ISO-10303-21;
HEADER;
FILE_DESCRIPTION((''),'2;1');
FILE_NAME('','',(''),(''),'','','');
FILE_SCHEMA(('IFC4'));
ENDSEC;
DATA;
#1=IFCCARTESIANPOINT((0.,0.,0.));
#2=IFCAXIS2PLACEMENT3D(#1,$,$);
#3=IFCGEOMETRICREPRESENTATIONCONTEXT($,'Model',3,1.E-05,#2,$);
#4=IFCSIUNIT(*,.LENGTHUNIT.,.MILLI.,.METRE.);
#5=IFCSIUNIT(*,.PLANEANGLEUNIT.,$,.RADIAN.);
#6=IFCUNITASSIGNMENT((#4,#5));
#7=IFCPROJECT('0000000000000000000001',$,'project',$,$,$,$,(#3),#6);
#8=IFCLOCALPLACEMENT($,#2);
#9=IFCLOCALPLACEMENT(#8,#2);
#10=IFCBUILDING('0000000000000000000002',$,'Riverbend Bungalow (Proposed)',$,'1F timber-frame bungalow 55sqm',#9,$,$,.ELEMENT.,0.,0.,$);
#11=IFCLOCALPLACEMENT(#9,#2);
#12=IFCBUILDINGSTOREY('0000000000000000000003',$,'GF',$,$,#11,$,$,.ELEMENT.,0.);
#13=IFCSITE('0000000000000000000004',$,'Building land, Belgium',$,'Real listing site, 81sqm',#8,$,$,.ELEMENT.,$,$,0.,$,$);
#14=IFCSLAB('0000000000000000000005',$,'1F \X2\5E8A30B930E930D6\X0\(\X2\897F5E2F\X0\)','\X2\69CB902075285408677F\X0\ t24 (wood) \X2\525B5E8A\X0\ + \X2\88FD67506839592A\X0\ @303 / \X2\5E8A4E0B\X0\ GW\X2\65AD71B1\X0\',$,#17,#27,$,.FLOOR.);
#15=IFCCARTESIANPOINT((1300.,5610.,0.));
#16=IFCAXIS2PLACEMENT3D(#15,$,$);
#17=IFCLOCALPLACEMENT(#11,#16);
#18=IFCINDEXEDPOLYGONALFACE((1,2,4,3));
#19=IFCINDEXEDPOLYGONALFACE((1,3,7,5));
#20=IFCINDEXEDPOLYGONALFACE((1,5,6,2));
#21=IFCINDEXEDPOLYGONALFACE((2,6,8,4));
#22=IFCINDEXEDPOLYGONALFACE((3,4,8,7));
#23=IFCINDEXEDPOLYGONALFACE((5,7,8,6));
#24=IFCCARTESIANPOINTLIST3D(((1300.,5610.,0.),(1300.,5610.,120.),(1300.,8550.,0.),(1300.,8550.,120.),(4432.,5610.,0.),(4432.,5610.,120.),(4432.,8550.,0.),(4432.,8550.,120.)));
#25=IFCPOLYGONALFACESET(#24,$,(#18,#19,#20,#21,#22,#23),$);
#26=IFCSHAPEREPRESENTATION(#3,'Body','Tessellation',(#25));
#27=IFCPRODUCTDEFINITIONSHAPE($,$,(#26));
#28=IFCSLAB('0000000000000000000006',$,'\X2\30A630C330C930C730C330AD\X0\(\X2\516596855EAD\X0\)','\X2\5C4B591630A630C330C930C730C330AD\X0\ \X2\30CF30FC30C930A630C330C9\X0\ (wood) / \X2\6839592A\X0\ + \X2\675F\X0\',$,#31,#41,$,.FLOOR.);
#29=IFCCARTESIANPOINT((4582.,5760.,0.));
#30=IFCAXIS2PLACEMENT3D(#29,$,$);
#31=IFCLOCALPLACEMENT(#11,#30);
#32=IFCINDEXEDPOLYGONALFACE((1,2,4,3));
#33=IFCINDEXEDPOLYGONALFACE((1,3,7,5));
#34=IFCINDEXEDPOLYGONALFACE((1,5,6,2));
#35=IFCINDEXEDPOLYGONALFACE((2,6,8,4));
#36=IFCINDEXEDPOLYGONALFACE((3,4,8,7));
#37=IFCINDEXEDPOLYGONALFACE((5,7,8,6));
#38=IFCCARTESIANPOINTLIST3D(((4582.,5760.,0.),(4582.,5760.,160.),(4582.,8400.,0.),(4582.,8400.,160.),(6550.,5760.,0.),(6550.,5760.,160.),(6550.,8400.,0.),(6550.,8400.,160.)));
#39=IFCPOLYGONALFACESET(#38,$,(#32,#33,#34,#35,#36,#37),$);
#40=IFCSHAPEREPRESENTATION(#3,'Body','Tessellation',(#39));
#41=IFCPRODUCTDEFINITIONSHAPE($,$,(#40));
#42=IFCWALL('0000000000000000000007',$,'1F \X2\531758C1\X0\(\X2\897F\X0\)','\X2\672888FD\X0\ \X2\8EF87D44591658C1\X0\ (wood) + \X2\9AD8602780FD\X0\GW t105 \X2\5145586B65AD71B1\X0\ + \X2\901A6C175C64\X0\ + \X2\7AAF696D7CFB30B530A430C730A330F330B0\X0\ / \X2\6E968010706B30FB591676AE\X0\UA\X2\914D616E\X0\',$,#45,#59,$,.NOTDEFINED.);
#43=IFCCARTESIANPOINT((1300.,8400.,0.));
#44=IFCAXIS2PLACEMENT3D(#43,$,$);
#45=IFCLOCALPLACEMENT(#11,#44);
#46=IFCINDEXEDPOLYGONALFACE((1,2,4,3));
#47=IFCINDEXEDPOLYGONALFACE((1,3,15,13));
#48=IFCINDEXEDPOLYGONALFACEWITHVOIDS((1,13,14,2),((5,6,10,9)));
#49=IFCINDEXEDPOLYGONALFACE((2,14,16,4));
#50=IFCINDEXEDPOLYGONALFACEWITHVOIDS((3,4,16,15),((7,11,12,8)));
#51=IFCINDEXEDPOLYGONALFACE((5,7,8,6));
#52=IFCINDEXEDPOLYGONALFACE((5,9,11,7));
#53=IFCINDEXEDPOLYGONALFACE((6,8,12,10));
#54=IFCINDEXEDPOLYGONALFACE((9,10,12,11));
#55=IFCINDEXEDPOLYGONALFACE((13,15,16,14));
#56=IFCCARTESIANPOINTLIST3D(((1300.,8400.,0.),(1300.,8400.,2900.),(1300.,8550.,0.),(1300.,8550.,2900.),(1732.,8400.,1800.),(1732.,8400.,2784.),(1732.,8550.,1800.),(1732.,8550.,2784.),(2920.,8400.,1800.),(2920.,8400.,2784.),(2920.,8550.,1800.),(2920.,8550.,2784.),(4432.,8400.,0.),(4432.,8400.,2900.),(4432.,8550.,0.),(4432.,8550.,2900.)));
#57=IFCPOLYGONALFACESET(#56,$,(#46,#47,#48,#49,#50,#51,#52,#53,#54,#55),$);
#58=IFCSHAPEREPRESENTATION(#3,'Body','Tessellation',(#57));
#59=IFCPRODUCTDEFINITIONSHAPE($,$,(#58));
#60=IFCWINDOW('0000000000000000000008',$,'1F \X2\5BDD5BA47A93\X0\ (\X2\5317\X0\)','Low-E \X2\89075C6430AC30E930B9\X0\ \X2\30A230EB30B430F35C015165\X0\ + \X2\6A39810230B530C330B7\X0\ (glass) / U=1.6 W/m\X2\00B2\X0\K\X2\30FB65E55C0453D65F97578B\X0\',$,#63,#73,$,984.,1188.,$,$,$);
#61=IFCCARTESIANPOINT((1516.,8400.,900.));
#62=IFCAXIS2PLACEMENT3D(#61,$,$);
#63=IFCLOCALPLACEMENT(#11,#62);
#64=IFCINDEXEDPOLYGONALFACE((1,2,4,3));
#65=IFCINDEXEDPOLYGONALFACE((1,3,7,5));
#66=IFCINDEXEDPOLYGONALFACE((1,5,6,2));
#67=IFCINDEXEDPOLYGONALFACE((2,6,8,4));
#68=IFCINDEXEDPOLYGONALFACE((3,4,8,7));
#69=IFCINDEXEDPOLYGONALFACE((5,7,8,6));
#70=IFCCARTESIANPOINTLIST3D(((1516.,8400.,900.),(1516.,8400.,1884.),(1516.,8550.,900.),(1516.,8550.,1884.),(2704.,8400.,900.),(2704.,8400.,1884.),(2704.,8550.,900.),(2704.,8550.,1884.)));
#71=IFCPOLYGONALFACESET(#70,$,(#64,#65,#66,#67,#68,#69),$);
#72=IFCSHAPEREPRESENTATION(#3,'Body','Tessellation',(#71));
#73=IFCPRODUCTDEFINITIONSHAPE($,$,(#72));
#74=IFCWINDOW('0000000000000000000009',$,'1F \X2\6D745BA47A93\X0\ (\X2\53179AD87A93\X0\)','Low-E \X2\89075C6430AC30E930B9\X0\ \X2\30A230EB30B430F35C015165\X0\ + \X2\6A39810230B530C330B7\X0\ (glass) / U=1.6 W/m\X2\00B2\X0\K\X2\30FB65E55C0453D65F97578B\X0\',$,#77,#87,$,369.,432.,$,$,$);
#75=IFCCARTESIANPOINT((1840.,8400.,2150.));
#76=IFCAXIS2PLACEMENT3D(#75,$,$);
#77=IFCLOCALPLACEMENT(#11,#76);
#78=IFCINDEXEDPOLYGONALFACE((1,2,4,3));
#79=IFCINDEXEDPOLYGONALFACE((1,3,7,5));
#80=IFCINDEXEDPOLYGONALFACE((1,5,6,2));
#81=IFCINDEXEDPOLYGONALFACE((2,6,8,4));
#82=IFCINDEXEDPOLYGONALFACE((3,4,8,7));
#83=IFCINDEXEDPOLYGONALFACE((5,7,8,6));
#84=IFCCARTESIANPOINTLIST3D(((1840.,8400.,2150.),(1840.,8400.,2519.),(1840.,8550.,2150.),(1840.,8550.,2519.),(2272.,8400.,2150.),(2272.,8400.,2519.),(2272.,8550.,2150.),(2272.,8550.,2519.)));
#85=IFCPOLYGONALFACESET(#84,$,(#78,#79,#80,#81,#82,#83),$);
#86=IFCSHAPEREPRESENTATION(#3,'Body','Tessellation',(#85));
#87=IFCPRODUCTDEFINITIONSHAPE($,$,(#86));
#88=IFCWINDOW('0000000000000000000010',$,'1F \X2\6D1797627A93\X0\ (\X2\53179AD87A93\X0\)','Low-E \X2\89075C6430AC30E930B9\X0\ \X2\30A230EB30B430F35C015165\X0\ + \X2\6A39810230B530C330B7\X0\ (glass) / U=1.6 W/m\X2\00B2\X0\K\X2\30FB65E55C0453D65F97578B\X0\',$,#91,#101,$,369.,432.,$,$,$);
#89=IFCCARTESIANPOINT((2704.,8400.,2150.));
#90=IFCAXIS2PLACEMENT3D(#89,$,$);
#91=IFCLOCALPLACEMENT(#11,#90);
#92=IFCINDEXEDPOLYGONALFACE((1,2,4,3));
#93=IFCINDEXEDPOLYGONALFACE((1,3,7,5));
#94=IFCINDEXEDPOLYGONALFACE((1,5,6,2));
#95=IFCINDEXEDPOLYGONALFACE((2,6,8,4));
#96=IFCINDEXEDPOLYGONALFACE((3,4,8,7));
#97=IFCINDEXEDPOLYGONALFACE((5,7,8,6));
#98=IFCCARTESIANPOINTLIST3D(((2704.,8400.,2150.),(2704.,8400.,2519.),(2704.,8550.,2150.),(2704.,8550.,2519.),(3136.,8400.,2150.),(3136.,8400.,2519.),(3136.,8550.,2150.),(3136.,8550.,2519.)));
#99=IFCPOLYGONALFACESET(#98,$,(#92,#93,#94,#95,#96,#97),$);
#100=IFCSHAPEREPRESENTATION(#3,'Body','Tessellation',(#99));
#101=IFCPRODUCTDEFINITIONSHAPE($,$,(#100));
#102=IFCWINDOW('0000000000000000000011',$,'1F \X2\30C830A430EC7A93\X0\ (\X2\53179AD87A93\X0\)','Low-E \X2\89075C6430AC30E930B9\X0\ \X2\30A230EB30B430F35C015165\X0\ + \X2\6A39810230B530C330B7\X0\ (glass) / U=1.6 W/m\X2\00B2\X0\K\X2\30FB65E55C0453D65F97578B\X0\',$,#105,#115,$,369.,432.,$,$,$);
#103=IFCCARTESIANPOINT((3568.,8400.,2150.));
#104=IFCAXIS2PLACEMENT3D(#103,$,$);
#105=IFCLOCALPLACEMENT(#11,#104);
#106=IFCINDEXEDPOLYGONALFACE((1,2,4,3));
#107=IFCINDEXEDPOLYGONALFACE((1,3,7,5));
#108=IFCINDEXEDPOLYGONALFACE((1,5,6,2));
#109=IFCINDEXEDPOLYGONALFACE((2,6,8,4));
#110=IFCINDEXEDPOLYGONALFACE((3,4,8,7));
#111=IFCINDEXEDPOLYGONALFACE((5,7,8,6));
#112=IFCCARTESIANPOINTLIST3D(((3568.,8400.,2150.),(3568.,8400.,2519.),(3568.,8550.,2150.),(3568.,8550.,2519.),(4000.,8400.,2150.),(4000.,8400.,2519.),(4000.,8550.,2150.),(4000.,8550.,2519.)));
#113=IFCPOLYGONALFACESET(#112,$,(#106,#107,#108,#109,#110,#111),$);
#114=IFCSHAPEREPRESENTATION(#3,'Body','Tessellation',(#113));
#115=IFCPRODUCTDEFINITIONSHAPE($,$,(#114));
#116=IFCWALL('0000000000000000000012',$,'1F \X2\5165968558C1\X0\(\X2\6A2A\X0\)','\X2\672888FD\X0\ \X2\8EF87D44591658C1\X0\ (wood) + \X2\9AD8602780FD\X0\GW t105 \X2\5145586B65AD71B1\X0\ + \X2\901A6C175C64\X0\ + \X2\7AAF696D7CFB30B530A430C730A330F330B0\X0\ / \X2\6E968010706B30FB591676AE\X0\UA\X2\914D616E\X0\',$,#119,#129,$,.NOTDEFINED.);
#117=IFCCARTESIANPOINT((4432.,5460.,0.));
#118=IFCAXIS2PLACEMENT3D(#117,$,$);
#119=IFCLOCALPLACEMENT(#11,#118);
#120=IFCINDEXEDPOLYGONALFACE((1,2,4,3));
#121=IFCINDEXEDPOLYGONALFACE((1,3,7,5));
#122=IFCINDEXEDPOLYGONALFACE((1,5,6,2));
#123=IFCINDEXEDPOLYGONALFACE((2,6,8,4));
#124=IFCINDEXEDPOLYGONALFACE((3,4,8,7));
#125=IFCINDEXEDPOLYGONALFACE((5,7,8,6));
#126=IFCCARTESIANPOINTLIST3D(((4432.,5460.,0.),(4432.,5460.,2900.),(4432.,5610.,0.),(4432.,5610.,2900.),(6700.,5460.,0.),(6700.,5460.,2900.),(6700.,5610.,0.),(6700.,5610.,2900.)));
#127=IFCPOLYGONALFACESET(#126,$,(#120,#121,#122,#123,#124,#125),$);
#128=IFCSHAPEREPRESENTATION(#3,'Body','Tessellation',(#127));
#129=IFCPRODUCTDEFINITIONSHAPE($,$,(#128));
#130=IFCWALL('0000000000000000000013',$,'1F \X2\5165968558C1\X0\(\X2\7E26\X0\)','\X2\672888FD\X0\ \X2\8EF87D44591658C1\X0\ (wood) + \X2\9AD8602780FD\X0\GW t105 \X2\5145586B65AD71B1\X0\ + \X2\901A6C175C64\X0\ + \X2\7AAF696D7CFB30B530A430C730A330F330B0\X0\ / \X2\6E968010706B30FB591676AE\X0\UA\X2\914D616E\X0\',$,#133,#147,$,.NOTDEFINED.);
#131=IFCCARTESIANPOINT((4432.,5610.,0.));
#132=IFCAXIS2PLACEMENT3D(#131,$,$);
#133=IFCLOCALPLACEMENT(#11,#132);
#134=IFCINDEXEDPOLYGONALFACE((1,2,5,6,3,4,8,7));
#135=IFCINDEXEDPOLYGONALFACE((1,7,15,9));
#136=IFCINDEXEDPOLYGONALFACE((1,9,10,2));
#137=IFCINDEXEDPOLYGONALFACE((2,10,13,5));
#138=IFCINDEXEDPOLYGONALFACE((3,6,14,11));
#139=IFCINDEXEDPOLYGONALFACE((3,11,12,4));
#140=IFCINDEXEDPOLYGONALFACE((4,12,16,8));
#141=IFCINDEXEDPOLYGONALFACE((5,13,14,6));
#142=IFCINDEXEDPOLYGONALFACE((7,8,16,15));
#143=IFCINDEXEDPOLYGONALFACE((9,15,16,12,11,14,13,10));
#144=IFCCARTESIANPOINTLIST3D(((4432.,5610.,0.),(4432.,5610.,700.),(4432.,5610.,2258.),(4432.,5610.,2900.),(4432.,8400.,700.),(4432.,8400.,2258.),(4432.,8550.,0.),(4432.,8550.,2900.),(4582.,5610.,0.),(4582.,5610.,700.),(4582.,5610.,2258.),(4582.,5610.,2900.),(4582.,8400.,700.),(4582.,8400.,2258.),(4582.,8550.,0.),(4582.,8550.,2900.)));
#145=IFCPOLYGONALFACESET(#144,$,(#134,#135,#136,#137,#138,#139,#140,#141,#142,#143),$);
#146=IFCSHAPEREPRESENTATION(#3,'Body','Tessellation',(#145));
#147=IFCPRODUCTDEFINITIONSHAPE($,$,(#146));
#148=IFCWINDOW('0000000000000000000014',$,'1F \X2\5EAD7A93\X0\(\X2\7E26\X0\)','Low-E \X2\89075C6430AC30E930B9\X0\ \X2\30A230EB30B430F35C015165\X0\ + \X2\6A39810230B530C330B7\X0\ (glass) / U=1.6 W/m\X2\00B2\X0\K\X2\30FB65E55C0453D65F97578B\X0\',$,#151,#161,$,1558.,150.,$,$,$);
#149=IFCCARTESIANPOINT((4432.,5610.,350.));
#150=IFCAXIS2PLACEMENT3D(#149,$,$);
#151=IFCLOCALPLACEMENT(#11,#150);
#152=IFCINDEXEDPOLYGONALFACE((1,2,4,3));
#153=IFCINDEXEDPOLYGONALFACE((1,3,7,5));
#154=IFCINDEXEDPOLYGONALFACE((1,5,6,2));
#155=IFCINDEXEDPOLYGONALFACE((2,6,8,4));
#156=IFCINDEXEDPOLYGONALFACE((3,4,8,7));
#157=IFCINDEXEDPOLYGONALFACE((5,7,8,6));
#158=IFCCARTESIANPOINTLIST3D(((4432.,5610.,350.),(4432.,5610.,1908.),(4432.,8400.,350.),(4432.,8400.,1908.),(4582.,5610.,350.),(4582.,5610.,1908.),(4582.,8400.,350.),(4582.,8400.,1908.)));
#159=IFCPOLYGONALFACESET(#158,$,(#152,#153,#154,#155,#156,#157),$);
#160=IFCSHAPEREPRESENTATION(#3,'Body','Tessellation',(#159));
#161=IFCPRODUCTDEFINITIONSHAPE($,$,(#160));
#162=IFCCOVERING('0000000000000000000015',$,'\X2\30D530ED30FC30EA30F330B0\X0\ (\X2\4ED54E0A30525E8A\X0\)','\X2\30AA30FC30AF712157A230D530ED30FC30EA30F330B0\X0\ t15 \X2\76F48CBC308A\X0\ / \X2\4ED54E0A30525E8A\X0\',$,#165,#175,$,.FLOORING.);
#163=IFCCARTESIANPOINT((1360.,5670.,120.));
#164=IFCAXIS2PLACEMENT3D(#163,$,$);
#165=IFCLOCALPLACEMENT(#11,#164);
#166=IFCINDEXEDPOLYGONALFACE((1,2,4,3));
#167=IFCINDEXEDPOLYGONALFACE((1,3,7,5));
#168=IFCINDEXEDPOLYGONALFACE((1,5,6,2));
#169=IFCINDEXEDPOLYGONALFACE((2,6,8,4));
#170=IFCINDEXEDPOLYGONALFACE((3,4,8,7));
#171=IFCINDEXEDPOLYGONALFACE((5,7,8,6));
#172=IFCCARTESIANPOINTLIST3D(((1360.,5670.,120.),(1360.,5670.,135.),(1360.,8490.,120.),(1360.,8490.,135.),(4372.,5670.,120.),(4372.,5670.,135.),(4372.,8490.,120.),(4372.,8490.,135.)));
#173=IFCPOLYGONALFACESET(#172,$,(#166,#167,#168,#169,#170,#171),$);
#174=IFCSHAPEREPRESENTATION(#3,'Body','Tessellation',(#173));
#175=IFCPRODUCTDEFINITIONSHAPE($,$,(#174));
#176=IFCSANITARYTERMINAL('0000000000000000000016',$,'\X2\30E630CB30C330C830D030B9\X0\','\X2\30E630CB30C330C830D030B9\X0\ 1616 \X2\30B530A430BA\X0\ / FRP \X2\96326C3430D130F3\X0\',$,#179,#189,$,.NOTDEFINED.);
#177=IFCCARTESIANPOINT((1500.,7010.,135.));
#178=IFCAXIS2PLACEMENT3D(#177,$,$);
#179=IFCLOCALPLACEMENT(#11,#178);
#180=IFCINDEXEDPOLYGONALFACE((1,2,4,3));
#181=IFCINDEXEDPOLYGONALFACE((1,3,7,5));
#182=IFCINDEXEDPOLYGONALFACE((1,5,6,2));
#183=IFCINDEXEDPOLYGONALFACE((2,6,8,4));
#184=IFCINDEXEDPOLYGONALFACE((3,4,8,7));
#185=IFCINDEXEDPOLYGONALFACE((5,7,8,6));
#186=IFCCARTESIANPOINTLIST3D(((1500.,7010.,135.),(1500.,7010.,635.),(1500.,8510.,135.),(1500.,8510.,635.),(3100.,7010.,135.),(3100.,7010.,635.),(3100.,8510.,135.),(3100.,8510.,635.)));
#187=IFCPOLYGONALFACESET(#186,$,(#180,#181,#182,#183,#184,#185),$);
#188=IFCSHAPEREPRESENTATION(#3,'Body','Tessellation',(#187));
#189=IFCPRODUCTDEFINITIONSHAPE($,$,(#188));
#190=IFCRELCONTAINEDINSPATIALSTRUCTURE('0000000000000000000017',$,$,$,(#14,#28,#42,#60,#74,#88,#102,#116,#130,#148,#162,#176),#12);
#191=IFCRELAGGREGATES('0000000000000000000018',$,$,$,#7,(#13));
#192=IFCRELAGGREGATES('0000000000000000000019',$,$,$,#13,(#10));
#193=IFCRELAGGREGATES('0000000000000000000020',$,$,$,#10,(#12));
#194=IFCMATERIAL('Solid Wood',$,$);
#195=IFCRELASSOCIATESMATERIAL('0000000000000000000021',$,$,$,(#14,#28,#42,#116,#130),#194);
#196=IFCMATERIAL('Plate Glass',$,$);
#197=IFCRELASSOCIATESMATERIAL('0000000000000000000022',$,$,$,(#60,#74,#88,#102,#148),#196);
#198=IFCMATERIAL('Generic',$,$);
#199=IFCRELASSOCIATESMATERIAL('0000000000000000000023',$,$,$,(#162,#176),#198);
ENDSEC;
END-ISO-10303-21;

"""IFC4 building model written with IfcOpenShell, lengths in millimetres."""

from ifc_helpers import new_model, si_unit, frame, frame_2d, origin, place, context, project, spatial, rectangle, extrude, material, element, fill, save


model = new_model("IFC4")

# Units and contexts
model_context = context("Model", 3, precision=1e-05, world=origin())
ifc_project = project(units=[si_unit("LENGTHUNIT", "METRE", prefix="MILLI"), si_unit("PLANEANGLEUNIT", "RADIAN")], contexts=[model_context])

# Site, building, storey
site_placement = place(None, origin())
site = spatial("IfcSite", under=ifc_project, at=site_placement, Name="Building land, Belgium", ObjectType="Real listing site, 81sqm", CompositionType="ELEMENT", RefElevation=0.0)
building_placement = place(site_placement, origin())
building = spatial("IfcBuilding", under=site, at=building_placement, Name="Riverbend Bungalow (Proposed)", ObjectType="1F timber-frame bungalow 55sqm", CompositionType="ELEMENT", ElevationOfRefHeight=0.0, ElevationOfTerrain=0.0)
storey_placement = place(building_placement, origin())
storey = spatial("IfcBuildingStorey", under=building, at=storey_placement, Name="GF", CompositionType="ELEMENT", Elevation=0.0)

# Slabs
ifc_material_1 = material(Name="Solid Wood")
slab_1_placement = place(storey_placement, frame((1300.0, 5610.0, 0.0)))
element("IfcSlab", 1, at=slab_1_placement, inside=storey, material=ifc_material_1, Name="1F 床スラブ(西帯)", Description="構造用合板 t24 (wood) 剛床 + 製材根太 @303 / 床下 GW断熱", PredefinedType="FLOOR", context=model_context, shape_type="SweptSolid", body=[
    extrude(rectangle(XDim=3132.0, YDim=2940.0, at=frame_2d((1566.0, 1470.0))), frame((1300.0, 5610.0, 0.0)), (0.0, 0.0, 1.0), 120.0),
])
slab_2_placement = place(storey_placement, frame((4582.0, 5760.0, 0.0)))
element("IfcSlab", 2, at=slab_2_placement, inside=storey, material=ifc_material_1, Name="ウッドデッキ(入隅庭)", Description="屋外ウッドデッキ ハードウッド (wood) / 根太 + 束", PredefinedType="FLOOR", context=model_context, shape_type="SweptSolid", body=[
    extrude(rectangle(XDim=1968.0, YDim=2640.0, at=frame_2d((984.0, 1320.0))), frame((4582.0, 5760.0, 0.0)), (0.0, 0.0, 1.0), 160.0),
])

# Wall, openings, windows
wall_1_placement = place(storey_placement, frame((1300.0, 8400.0, 0.0)))
wall_1 = element("IfcWall", 3, at=wall_1_placement, inside=storey, material=ifc_material_1, Name="1F 北壁(西)", Description="木製 軸組外壁 (wood) + 高性能GW t105 充填断熱 + 通気層 + 窯業系サイディング / 準耐火・外皮UA配慮", PredefinedType="NOTDEFINED", context=model_context, shape_type="SweptSolid", body=[
    extrude(rectangle(XDim=3132.0, YDim=150.0, at=frame_2d((1566.0, 75.0))), frame((1300.0, 8400.0, 0.0)), (0.0, 0.0, 1.0), 2900.0),
])
opening_1_placement = place(storey_placement, frame((1516.0, 8400.0, 900.0)))
opening_1 = element("IfcOpeningElement", 4, at=opening_1_placement, cuts=wall_1, PredefinedType="NOTDEFINED", context=model_context, shape_type="SweptSolid", body=[
    extrude(rectangle(XDim=1188.0, YDim=150.0, at=frame_2d((594.0, 75.0))), frame((1516.0, 8400.0, 900.0)), (0.0, 0.0, 1.0), 984.0),
])
opening_2_placement = place(storey_placement, frame((1840.0, 8400.0, 2150.0)))
opening_2 = element("IfcOpeningElement", 5, at=opening_2_placement, cuts=wall_1, PredefinedType="NOTDEFINED", context=model_context, shape_type="SweptSolid", body=[
    extrude(rectangle(XDim=432.0, YDim=150.0, at=frame_2d((216.0, 75.0))), frame((1840.0, 8400.0, 2150.0)), (0.0, 0.0, 1.0), 369.0),
])
opening_3_placement = place(storey_placement, frame((2704.0, 8400.0, 2150.0)))
opening_3 = element("IfcOpeningElement", 6, at=opening_3_placement, cuts=wall_1, PredefinedType="NOTDEFINED", context=model_context, shape_type="SweptSolid", body=[
    extrude(rectangle(XDim=432.0, YDim=150.0, at=frame_2d((216.0, 75.0))), frame((2704.0, 8400.0, 2150.0)), (0.0, 0.0, 1.0), 369.0),
])
opening_4_placement = place(storey_placement, frame((3568.0, 8400.0, 2150.0)))
opening_4 = element("IfcOpeningElement", 7, at=opening_4_placement, cuts=wall_1, PredefinedType="NOTDEFINED", context=model_context, shape_type="SweptSolid", body=[
    extrude(rectangle(XDim=432.0, YDim=150.0, at=frame_2d((216.0, 75.0))), frame((3568.0, 8400.0, 2150.0)), (0.0, 0.0, 1.0), 369.0),
])
ifc_material_2 = material(Name="Plate Glass")
window_1_placement = place(storey_placement, frame((1516.0, 8400.0, 900.0)))
window_1 = element("IfcWindow", 8, at=window_1_placement, inside=storey, material=ifc_material_2, Name="1F 寝室窓 (北)", Description="Low-E 複層ガラス アルゴン封入 + 樹脂サッシ (glass) / U=1.6 W/m²K・日射取得型", OverallHeight=984.0, OverallWidth=1188.0, context=model_context, shape_type="SweptSolid", body=[
    extrude(rectangle(XDim=1188.0, YDim=150.0, at=frame_2d((594.0, 75.0))), frame((1516.0, 8400.0, 900.0)), (0.0, 0.0, 1.0), 984.0),
])
fill(opening_1, window_1)
window_2_placement = place(storey_placement, frame((1840.0, 8400.0, 2150.0)))
window_2 = element("IfcWindow", 9, at=window_2_placement, inside=storey, material=ifc_material_2, Name="1F 浴室窓 (北高窓)", Description="Low-E 複層ガラス アルゴン封入 + 樹脂サッシ (glass) / U=1.6 W/m²K・日射取得型", OverallHeight=369.0, OverallWidth=432.0, context=model_context, shape_type="SweptSolid", body=[
    extrude(rectangle(XDim=432.0, YDim=150.0, at=frame_2d((216.0, 75.0))), frame((1840.0, 8400.0, 2150.0)), (0.0, 0.0, 1.0), 369.0),
])
fill(opening_2, window_2)
window_3_placement = place(storey_placement, frame((2704.0, 8400.0, 2150.0)))
window_3 = element("IfcWindow", 10, at=window_3_placement, inside=storey, material=ifc_material_2, Name="1F 洗面窓 (北高窓)", Description="Low-E 複層ガラス アルゴン封入 + 樹脂サッシ (glass) / U=1.6 W/m²K・日射取得型", OverallHeight=369.0, OverallWidth=432.0, context=model_context, shape_type="SweptSolid", body=[
    extrude(rectangle(XDim=432.0, YDim=150.0, at=frame_2d((216.0, 75.0))), frame((2704.0, 8400.0, 2150.0)), (0.0, 0.0, 1.0), 369.0),
])
fill(opening_3, window_3)
window_4_placement = place(storey_placement, frame((3568.0, 8400.0, 2150.0)))
window_4 = element("IfcWindow", 11, at=window_4_placement, inside=storey, material=ifc_material_2, Name="1F トイレ窓 (北高窓)", Description="Low-E 複層ガラス アルゴン封入 + 樹脂サッシ (glass) / U=1.6 W/m²K・日射取得型", OverallHeight=369.0, OverallWidth=432.0, context=model_context, shape_type="SweptSolid", body=[
    extrude(rectangle(XDim=432.0, YDim=150.0, at=frame_2d((216.0, 75.0))), frame((3568.0, 8400.0, 2150.0)), (0.0, 0.0, 1.0), 369.0),
])
fill(opening_4, window_4)

# Wall
wall_2_placement = place(storey_placement, frame((4432.0, 5460.0, 0.0)))
element("IfcWall", 12, at=wall_2_placement, inside=storey, material=ifc_material_1, Name="1F 入隅壁(横)", Description="木製 軸組外壁 (wood) + 高性能GW t105 充填断熱 + 通気層 + 窯業系サイディング / 準耐火・外皮UA配慮", PredefinedType="NOTDEFINED", context=model_context, shape_type="SweptSolid", body=[
    extrude(rectangle(XDim=2268.0, YDim=150.0, at=frame_2d((1134.0, 75.0))), frame((4432.0, 5460.0, 0.0)), (0.0, 0.0, 1.0), 2900.0),
])

# Wall, opening, window
wall_3_placement = place(storey_placement, frame((4432.0, 5610.0, 0.0)))
wall_3 = element("IfcWall", 13, at=wall_3_placement, inside=storey, material=ifc_material_1, Name="1F 入隅壁(縦)", Description="木製 軸組外壁 (wood) + 高性能GW t105 充填断熱 + 通気層 + 窯業系サイディング / 準耐火・外皮UA配慮", PredefinedType="NOTDEFINED", context=model_context, shape_type="SweptSolid", body=[
    extrude(rectangle(XDim=150.0, YDim=2940.0, at=frame_2d((75.0, 1470.0))), frame((4432.0, 5610.0, 0.0)), (0.0, 0.0, 1.0), 2900.0),
])
opening_5_placement = place(storey_placement, frame((4432.0, 5610.0, 350.0)))
opening_5 = element("IfcOpeningElement", 14, at=opening_5_placement, cuts=wall_3, PredefinedType="NOTDEFINED", context=model_context, shape_type="SweptSolid", body=[
    extrude(rectangle(XDim=150.0, YDim=2790.0, at=frame_2d((75.0, 1395.0))), frame((4432.0, 5610.0, 350.0)), (0.0, 0.0, 1.0), 1558.0),
])
window_5_placement = place(storey_placement, frame((4432.0, 5610.0, 350.0)))
window_5 = element("IfcWindow", 15, at=window_5_placement, inside=storey, material=ifc_material_2, Name="1F 庭窓(縦)", Description="Low-E 複層ガラス アルゴン封入 + 樹脂サッシ (glass) / U=1.6 W/m²K・日射取得型", OverallHeight=1558.0, OverallWidth=150.0, context=model_context, shape_type="SweptSolid", body=[
    extrude(rectangle(XDim=150.0, YDim=2790.0, at=frame_2d((75.0, 1395.0))), frame((4432.0, 5610.0, 350.0)), (0.0, 0.0, 1.0), 1558.0),
])
fill(opening_5, window_5)

# Covering
ifc_material_3 = material(Name="Generic")
covering_placement = place(storey_placement, frame((1360.0, 5670.0, 120.0)))
element("IfcCovering", 16, at=covering_placement, inside=storey, material=ifc_material_3, Name="フローリング (仕上げ床)", Description="オーク無垢フローリング t15 直貼り / 仕上げ床", PredefinedType="FLOORING", context=model_context, shape_type="SweptSolid", body=[
    extrude(rectangle(XDim=3012.0, YDim=2820.0, at=frame_2d((1506.0, 1410.0))), frame((1360.0, 5670.0, 120.0)), (0.0, 0.0, 1.0), 15.0),
])

# Sanitary terminal
sanitary_terminal_1_placement = place(storey_placement, frame((1500.0, 7010.0, 135.0)))
element("IfcSanitaryTerminal", 17, at=sanitary_terminal_1_placement, inside=storey, material=ifc_material_3, Name="ユニットバス", Description="ユニットバス 1616 サイズ / FRP 防水パン", PredefinedType="NOTDEFINED", context=model_context, shape_type="SweptSolid", body=[
    extrude(rectangle(XDim=1600.0, YDim=1500.0, at=frame_2d((800.0, 750.0))), frame((1500.0, 7010.0, 135.0)), (0.0, 0.0, 1.0), 500.0),
])

save(model, "model.ifc")
